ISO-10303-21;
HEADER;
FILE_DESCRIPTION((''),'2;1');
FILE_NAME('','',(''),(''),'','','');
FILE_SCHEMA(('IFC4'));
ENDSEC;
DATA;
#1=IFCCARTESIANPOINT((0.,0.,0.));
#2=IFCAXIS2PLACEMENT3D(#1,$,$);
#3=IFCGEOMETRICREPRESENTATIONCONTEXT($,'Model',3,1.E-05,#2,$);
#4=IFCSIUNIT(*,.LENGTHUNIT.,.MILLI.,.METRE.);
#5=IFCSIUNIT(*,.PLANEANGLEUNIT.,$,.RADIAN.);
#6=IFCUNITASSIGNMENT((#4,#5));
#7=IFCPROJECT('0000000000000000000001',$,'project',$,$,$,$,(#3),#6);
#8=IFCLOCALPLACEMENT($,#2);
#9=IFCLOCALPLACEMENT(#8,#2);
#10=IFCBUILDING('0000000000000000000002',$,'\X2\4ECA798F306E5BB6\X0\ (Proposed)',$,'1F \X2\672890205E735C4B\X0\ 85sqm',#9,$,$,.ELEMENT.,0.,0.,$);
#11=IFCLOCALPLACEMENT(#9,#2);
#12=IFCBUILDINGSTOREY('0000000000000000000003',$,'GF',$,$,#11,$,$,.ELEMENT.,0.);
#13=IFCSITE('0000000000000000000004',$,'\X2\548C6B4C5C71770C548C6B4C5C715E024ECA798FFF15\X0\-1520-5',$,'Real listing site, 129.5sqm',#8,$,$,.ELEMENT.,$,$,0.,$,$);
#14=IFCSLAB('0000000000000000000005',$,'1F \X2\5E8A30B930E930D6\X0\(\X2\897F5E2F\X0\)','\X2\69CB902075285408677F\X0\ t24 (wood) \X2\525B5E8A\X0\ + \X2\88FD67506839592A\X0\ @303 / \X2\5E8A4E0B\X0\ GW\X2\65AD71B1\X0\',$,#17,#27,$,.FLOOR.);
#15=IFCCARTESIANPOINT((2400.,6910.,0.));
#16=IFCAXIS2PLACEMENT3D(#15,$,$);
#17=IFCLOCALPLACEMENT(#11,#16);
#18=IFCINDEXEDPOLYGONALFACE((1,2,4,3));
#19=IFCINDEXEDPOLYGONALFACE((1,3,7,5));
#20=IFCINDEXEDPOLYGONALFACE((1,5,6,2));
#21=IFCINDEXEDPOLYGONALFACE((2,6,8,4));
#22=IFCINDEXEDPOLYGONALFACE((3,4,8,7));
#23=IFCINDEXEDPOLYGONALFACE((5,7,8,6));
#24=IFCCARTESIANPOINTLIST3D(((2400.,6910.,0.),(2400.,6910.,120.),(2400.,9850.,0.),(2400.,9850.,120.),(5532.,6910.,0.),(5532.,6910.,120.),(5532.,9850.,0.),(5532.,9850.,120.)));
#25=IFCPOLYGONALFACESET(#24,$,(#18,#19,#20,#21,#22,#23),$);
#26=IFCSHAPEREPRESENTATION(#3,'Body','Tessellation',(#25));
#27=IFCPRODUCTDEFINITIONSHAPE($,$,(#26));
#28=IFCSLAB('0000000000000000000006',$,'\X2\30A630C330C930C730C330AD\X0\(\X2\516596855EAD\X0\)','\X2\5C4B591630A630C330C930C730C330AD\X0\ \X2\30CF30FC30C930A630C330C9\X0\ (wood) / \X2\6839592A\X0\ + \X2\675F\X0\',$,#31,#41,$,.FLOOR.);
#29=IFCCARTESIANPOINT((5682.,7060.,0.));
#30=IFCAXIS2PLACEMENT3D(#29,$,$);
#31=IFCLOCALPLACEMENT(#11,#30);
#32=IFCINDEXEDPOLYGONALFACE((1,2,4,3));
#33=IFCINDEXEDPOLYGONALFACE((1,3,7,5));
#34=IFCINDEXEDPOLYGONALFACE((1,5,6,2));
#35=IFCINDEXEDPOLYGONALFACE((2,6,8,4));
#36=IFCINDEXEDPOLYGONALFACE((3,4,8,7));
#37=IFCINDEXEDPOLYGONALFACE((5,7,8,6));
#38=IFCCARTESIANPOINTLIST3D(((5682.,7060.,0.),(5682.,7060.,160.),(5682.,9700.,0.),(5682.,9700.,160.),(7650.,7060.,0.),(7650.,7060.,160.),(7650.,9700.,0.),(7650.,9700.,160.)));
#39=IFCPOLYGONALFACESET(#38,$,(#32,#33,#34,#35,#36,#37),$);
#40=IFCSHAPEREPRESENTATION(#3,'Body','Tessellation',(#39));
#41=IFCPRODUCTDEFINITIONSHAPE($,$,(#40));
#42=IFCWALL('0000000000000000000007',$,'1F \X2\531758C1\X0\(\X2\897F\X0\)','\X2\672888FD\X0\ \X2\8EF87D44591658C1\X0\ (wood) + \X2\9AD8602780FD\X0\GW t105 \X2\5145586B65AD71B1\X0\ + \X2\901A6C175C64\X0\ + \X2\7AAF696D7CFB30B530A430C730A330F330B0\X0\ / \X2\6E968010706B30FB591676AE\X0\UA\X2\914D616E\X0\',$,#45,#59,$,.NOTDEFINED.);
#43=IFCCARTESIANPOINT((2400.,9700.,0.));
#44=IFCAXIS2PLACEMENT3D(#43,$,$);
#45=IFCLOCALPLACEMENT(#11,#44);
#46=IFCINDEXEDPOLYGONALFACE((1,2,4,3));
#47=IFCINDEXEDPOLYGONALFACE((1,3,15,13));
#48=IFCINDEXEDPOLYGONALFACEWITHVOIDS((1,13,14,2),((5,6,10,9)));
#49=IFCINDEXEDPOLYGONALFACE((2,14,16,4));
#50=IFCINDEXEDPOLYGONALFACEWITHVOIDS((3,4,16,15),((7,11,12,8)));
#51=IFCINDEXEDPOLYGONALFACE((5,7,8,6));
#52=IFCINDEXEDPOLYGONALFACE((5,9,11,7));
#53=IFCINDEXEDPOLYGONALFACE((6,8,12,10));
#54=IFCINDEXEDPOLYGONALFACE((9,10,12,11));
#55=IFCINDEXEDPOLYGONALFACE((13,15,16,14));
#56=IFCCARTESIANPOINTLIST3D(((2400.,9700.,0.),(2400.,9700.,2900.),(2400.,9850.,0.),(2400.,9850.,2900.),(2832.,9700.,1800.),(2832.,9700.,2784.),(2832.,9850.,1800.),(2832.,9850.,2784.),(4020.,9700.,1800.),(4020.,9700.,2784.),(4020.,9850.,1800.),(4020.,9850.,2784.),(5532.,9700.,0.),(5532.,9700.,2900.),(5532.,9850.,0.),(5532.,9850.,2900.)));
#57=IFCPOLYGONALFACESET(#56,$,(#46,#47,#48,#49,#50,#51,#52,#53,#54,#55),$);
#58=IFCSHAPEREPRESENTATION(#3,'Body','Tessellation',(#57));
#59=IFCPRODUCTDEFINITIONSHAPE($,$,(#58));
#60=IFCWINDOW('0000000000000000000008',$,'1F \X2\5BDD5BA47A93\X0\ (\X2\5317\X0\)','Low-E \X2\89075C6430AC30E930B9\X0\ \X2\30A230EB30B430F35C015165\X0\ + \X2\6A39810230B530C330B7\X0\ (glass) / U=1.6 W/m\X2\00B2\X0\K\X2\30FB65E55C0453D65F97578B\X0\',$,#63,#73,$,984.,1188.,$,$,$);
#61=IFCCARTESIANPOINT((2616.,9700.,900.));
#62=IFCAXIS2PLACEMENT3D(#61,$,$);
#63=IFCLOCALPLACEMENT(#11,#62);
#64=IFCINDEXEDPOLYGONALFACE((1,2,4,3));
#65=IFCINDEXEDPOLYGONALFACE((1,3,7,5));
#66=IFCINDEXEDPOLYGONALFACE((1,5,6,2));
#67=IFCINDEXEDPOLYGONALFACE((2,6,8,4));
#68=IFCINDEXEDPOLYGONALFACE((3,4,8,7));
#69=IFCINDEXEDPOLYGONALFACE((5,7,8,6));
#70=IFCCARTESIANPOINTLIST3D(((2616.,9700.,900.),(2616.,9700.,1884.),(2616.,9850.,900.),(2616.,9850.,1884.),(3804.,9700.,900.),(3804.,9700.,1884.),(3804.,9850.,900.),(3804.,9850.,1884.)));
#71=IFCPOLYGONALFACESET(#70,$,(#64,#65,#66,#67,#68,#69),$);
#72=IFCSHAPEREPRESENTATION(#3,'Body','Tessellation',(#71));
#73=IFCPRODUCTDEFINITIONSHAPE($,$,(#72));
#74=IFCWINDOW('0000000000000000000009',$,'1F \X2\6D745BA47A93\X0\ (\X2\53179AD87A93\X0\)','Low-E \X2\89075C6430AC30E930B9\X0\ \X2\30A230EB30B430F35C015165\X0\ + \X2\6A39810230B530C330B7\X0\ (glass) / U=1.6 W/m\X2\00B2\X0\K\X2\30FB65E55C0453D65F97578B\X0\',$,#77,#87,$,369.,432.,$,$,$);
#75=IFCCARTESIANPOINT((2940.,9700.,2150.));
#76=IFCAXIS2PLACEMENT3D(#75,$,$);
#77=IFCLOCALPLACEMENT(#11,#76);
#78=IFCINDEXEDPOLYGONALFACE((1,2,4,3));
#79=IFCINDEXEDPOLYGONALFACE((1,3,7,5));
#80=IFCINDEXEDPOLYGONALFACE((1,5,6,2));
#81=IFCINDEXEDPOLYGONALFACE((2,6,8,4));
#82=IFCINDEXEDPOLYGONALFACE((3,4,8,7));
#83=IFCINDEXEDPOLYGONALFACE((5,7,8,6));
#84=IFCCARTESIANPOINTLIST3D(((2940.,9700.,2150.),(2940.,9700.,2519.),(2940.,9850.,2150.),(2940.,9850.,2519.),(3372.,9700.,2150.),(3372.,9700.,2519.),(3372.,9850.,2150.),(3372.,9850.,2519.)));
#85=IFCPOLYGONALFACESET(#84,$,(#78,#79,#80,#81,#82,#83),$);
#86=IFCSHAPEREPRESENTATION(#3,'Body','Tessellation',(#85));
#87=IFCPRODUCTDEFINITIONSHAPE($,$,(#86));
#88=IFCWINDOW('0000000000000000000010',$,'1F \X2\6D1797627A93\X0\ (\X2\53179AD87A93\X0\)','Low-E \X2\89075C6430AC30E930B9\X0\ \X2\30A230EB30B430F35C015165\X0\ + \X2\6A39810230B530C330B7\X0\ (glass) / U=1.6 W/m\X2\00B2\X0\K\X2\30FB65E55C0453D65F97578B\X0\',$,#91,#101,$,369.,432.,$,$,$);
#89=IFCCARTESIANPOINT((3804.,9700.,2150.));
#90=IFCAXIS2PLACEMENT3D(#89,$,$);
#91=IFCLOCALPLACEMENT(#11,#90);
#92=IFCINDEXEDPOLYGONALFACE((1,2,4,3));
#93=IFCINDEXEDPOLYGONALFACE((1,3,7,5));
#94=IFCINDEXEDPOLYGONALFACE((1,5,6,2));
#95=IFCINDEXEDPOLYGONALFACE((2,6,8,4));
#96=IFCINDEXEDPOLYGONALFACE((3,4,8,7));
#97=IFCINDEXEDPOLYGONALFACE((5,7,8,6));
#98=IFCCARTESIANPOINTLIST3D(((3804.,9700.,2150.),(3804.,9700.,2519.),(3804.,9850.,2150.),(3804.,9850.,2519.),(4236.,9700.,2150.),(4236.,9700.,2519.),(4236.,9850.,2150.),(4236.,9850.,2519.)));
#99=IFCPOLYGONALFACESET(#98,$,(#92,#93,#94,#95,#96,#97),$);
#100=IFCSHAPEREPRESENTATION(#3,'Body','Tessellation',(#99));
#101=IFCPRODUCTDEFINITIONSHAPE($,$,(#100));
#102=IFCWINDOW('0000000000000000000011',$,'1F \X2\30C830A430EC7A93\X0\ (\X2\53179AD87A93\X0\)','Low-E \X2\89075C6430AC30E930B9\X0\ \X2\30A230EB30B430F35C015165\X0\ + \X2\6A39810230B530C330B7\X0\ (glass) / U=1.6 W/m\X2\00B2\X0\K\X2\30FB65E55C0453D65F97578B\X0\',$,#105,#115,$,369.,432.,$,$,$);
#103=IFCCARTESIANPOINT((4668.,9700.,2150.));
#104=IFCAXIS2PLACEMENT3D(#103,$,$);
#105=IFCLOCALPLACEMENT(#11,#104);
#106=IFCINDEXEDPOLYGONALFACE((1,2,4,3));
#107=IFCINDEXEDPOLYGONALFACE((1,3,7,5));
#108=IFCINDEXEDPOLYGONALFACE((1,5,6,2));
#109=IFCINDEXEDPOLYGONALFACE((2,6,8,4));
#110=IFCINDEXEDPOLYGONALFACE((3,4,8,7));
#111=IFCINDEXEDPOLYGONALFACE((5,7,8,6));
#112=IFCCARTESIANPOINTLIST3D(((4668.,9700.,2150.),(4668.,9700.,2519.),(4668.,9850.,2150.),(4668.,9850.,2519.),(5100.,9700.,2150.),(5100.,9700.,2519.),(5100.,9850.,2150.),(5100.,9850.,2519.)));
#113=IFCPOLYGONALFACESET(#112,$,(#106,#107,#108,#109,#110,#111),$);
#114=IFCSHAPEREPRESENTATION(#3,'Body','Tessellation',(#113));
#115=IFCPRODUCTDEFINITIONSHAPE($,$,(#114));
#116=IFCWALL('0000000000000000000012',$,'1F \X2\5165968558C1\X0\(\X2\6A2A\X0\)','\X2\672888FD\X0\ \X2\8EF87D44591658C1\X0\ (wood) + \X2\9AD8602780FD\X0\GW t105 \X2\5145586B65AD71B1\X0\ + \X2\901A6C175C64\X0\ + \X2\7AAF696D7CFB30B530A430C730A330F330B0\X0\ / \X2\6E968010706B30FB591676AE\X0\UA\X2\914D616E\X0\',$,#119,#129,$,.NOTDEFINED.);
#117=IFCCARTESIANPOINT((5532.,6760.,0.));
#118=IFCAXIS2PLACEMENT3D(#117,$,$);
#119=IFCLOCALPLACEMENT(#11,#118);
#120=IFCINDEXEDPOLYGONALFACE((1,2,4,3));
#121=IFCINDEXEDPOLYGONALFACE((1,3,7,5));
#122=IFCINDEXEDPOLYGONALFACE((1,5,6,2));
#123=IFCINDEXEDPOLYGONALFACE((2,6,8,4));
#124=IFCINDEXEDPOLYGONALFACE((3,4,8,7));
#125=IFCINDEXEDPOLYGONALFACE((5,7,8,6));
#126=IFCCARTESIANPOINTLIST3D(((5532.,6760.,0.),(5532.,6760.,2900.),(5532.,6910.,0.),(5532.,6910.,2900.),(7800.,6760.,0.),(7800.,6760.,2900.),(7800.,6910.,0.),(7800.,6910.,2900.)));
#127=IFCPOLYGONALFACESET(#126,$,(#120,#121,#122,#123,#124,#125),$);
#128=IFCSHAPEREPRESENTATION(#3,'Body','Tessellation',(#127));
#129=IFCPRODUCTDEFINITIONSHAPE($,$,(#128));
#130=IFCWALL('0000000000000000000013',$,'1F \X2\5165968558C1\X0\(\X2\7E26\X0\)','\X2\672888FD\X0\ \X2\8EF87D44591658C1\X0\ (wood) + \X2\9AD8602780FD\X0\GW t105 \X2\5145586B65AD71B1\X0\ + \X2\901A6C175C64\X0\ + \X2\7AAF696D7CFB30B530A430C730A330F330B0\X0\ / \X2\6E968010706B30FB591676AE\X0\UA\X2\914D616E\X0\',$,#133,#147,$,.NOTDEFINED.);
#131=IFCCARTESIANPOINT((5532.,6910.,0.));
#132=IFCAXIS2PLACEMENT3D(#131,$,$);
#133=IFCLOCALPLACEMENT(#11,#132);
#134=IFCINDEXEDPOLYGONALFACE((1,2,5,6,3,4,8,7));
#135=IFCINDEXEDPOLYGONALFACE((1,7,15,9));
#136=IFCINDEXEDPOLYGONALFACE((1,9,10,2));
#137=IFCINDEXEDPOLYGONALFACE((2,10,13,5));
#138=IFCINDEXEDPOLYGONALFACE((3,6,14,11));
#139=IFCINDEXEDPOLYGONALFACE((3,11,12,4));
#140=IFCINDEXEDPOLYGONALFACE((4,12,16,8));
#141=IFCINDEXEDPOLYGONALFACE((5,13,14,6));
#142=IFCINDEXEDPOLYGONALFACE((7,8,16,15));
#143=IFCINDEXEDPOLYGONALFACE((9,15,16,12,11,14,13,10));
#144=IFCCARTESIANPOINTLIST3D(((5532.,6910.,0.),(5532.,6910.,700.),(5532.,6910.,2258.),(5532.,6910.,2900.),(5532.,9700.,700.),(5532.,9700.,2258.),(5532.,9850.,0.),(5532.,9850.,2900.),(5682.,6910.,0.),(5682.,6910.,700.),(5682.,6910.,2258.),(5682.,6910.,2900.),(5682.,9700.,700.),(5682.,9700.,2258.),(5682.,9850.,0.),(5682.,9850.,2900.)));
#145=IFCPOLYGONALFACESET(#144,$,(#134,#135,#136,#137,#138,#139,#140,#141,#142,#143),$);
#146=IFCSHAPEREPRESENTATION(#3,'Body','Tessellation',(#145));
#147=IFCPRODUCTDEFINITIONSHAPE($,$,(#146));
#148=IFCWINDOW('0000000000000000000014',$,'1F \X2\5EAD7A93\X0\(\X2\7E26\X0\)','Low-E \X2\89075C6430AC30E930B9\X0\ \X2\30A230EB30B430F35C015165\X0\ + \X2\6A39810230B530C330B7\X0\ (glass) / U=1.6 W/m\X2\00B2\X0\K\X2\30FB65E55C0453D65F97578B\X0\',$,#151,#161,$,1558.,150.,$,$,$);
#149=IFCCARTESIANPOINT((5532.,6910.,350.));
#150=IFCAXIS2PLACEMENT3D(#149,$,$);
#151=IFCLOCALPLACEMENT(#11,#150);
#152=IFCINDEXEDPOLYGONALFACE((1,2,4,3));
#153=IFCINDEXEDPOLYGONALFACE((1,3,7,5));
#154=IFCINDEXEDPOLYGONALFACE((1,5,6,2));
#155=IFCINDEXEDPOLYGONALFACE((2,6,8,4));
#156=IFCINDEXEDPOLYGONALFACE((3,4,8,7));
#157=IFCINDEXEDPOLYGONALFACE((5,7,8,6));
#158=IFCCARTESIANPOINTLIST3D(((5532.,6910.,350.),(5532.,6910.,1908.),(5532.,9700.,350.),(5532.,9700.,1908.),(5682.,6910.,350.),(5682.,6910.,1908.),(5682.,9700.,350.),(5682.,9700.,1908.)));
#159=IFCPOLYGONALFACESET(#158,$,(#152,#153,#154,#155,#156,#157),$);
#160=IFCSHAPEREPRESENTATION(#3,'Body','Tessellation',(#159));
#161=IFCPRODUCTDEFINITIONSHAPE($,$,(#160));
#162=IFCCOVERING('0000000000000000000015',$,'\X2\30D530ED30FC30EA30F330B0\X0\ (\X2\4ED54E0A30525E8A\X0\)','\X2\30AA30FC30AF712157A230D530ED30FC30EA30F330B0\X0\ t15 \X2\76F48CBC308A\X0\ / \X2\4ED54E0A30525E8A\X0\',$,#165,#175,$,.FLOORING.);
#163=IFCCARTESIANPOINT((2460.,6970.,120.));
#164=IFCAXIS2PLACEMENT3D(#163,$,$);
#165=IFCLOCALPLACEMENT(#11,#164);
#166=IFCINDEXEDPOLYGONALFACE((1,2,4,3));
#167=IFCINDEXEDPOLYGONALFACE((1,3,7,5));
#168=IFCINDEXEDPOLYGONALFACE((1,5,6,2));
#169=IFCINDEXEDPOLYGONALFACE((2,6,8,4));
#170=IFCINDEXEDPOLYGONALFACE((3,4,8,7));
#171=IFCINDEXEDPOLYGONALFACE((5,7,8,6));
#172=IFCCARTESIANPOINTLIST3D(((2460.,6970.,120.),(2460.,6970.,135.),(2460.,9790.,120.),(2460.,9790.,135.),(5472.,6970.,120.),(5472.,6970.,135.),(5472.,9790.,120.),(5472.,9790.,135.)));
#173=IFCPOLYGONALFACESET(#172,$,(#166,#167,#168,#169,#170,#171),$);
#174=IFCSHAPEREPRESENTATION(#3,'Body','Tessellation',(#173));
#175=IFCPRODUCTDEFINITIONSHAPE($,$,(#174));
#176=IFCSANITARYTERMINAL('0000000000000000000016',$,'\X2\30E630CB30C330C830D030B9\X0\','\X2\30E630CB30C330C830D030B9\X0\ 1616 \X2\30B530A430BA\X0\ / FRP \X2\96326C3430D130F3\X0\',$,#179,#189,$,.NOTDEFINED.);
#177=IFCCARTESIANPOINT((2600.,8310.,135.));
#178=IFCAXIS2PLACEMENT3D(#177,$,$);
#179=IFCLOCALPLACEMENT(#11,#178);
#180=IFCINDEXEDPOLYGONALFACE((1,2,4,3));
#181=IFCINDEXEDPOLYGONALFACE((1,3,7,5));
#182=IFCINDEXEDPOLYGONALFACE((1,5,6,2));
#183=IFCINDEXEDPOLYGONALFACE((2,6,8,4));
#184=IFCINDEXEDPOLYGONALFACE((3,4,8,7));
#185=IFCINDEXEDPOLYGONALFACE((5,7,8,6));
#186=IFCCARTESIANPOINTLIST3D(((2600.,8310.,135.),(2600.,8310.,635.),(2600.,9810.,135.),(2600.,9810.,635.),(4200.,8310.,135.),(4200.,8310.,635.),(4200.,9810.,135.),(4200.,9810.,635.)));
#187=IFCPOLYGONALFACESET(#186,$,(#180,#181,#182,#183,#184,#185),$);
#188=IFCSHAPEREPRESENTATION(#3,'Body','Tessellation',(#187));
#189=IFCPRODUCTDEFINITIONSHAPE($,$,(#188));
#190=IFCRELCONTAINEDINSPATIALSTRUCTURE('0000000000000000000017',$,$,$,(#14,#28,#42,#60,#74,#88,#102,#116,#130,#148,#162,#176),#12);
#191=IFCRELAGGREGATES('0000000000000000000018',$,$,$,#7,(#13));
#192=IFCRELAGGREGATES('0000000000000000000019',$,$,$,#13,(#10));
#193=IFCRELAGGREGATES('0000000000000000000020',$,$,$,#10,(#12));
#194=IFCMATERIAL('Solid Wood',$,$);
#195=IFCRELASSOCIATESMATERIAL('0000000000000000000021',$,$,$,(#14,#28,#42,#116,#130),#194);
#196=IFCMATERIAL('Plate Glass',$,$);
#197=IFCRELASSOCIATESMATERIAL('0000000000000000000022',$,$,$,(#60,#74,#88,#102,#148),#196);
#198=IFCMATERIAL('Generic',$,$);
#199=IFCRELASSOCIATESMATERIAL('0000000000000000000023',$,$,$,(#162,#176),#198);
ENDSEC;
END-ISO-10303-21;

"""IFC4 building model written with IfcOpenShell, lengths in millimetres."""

from ifc_helpers import new_model, si_unit, frame, frame_2d, origin, place, context, project, spatial, rectangle, extrude, material, element, fill, save


model = new_model("IFC4")

# Units and contexts
model_context = context("Model", 3, precision=1e-05, world=origin())
ifc_project = project(units=[si_unit("LENGTHUNIT", "METRE", prefix="MILLI"), si_unit("PLANEANGLEUNIT", "RADIAN")], contexts=[model_context])

# Site, building, storey
site_placement = place(None, origin())
site = spatial("IfcSite", under=ifc_project, at=site_placement, Name="和歌山県和歌山市今福５-1520-5", ObjectType="Real listing site, 129.5sqm", CompositionType="ELEMENT", RefElevation=0.0)
building_placement = place(site_placement, origin())
building = spatial("IfcBuilding", under=site, at=building_placement, Name="今福の家 (Proposed)", ObjectType="1F 木造平屋 85sqm", CompositionType="ELEMENT", ElevationOfRefHeight=0.0, ElevationOfTerrain=0.0)
storey_placement = place(building_placement, origin())
storey = spatial("IfcBuildingStorey", under=building, at=storey_placement, Name="GF", CompositionType="ELEMENT", Elevation=0.0)

# Slabs
ifc_material_1 = material(Name="Solid Wood")
slab_1_placement = place(storey_placement, frame((2400.0, 6910.0, 0.0)))
element("IfcSlab", 1, at=slab_1_placement, inside=storey, material=ifc_material_1, Name="1F 床スラブ(西帯)", Description="構造用合板 t24 (wood) 剛床 + 製材根太 @303 / 床下 GW断熱", PredefinedType="FLOOR", context=model_context, shape_type="SweptSolid", body=[
    extrude(rectangle(XDim=3132.0, YDim=2940.0, at=frame_2d((1566.0, 1470.0))), frame((2400.0, 6910.0, 0.0)), (0.0, 0.0, 1.0), 120.0),
])
slab_2_placement = place(storey_placement, frame((5682.0, 7060.0, 0.0)))
element("IfcSlab", 2, at=slab_2_placement, inside=storey, material=ifc_material_1, Name="ウッドデッキ(入隅庭)", Description="屋外ウッドデッキ ハードウッド (wood) / 根太 + 束", PredefinedType="FLOOR", context=model_context, shape_type="SweptSolid", body=[
    extrude(rectangle(XDim=1968.0, YDim=2640.0, at=frame_2d((984.0, 1320.0))), frame((5682.0, 7060.0, 0.0)), (0.0, 0.0, 1.0), 160.0),
])

# Wall, openings, windows
wall_1_placement = place(storey_placement, frame((2400.0, 9700.0, 0.0)))
wall_1 = element("IfcWall", 3, at=wall_1_placement, inside=storey, material=ifc_material_1, Name="1F 北壁(西)", Description="木製 軸組外壁 (wood) + 高性能GW t105 充填断熱 + 通気層 + 窯業系サイディング / 準耐火・外皮UA配慮", PredefinedType="NOTDEFINED", context=model_context, shape_type="SweptSolid", body=[
    extrude(rectangle(XDim=3132.0, YDim=150.0, at=frame_2d((1566.0, 75.0))), frame((2400.0, 9700.0, 0.0)), (0.0, 0.0, 1.0), 2900.0),
])
opening_1_placement = place(storey_placement, frame((2616.0, 9700.0, 900.0)))
opening_1 = element("IfcOpeningElement", 4, at=opening_1_placement, cuts=wall_1, PredefinedType="NOTDEFINED", context=model_context, shape_type="SweptSolid", body=[
    extrude(rectangle(XDim=1188.0, YDim=150.0, at=frame_2d((594.0, 75.0))), frame((2616.0, 9700.0, 900.0)), (0.0, 0.0, 1.0), 984.0),
])
opening_2_placement = place(storey_placement, frame((2940.0, 9700.0, 2150.0)))
opening_2 = element("IfcOpeningElement", 5, at=opening_2_placement, cuts=wall_1, PredefinedType="NOTDEFINED", context=model_context, shape_type="SweptSolid", body=[
    extrude(rectangle(XDim=432.0, YDim=150.0, at=frame_2d((216.0, 75.0))), frame((2940.0, 9700.0, 2150.0)), (0.0, 0.0, 1.0), 369.0),
])
opening_3_placement = place(storey_placement, frame((3804.0, 9700.0, 2150.0)))
opening_3 = element("IfcOpeningElement", 6, at=opening_3_placement, cuts=wall_1, PredefinedType="NOTDEFINED", context=model_context, shape_type="SweptSolid", body=[
    extrude(rectangle(XDim=432.0, YDim=150.0, at=frame_2d((216.0, 75.0))), frame((3804.0, 9700.0, 2150.0)), (0.0, 0.0, 1.0), 369.0),
])
opening_4_placement = place(storey_placement, frame((4668.0, 9700.0, 2150.0)))
opening_4 = element("IfcOpeningElement", 7, at=opening_4_placement, cuts=wall_1, PredefinedType="NOTDEFINED", context=model_context, shape_type="SweptSolid", body=[
    extrude(rectangle(XDim=432.0, YDim=150.0, at=frame_2d((216.0, 75.0))), frame((4668.0, 9700.0, 2150.0)), (0.0, 0.0, 1.0), 369.0),
])
ifc_material_2 = material(Name="Plate Glass")
window_1_placement = place(storey_placement, frame((2616.0, 9700.0, 900.0)))
window_1 = element("IfcWindow", 8, at=window_1_placement, inside=storey, material=ifc_material_2, Name="1F 寝室窓 (北)", Description="Low-E 複層ガラス アルゴン封入 + 樹脂サッシ (glass) / U=1.6 W/m²K・日射取得型", OverallHeight=984.0, OverallWidth=1188.0, context=model_context, shape_type="SweptSolid", body=[
    extrude(rectangle(XDim=1188.0, YDim=150.0, at=frame_2d((594.0, 75.0))), frame((2616.0, 9700.0, 900.0)), (0.0, 0.0, 1.0), 984.0),
])
fill(opening_1, window_1)
window_2_placement = place(storey_placement, frame((2940.0, 9700.0, 2150.0)))
window_2 = element("IfcWindow", 9, at=window_2_placement, inside=storey, material=ifc_material_2, Name="1F 浴室窓 (北高窓)", Description="Low-E 複層ガラス アルゴン封入 + 樹脂サッシ (glass) / U=1.6 W/m²K・日射取得型", OverallHeight=369.0, OverallWidth=432.0, context=model_context, shape_type="SweptSolid", body=[
    extrude(rectangle(XDim=432.0, YDim=150.0, at=frame_2d((216.0, 75.0))), frame((2940.0, 9700.0, 2150.0)), (0.0, 0.0, 1.0), 369.0),
])
fill(opening_2, window_2)
window_3_placement = place(storey_placement, frame((3804.0, 9700.0, 2150.0)))
window_3 = element("IfcWindow", 10, at=window_3_placement, inside=storey, material=ifc_material_2, Name="1F 洗面窓 (北高窓)", Description="Low-E 複層ガラス アルゴン封入 + 樹脂サッシ (glass) / U=1.6 W/m²K・日射取得型", OverallHeight=369.0, OverallWidth=432.0, context=model_context, shape_type="SweptSolid", body=[
    extrude(rectangle(XDim=432.0, YDim=150.0, at=frame_2d((216.0, 75.0))), frame((3804.0, 9700.0, 2150.0)), (0.0, 0.0, 1.0), 369.0),
])
fill(opening_3, window_3)
window_4_placement = place(storey_placement, frame((4668.0, 9700.0, 2150.0)))
window_4 = element("IfcWindow", 11, at=window_4_placement, inside=storey, material=ifc_material_2, Name="1F トイレ窓 (北高窓)", Description="Low-E 複層ガラス アルゴン封入 + 樹脂サッシ (glass) / U=1.6 W/m²K・日射取得型", OverallHeight=369.0, OverallWidth=432.0, context=model_context, shape_type="SweptSolid", body=[
    extrude(rectangle(XDim=432.0, YDim=150.0, at=frame_2d((216.0, 75.0))), frame((4668.0, 9700.0, 2150.0)), (0.0, 0.0, 1.0), 369.0),
])
fill(opening_4, window_4)

# Wall
wall_2_placement = place(storey_placement, frame((5532.0, 6760.0, 0.0)))
element("IfcWall", 12, at=wall_2_placement, inside=storey, material=ifc_material_1, Name="1F 入隅壁(横)", Description="木製 軸組外壁 (wood) + 高性能GW t105 充填断熱 + 通気層 + 窯業系サイディング / 準耐火・外皮UA配慮", PredefinedType="NOTDEFINED", context=model_context, shape_type="SweptSolid", body=[
    extrude(rectangle(XDim=2268.0, YDim=150.0, at=frame_2d((1134.0, 75.0))), frame((5532.0, 6760.0, 0.0)), (0.0, 0.0, 1.0), 2900.0),
])

# Wall, opening, window
wall_3_placement = place(storey_placement, frame((5532.0, 6910.0, 0.0)))
wall_3 = element("IfcWall", 13, at=wall_3_placement, inside=storey, material=ifc_material_1, Name="1F 入隅壁(縦)", Description="木製 軸組外壁 (wood) + 高性能GW t105 充填断熱 + 通気層 + 窯業系サイディング / 準耐火・外皮UA配慮", PredefinedType="NOTDEFINED", context=model_context, shape_type="SweptSolid", body=[
    extrude(rectangle(XDim=150.0, YDim=2940.0, at=frame_2d((75.0, 1470.0))), frame((5532.0, 6910.0, 0.0)), (0.0, 0.0, 1.0), 2900.0),
])
opening_5_placement = place(storey_placement, frame((5532.0, 6910.0, 350.0)))
opening_5 = element("IfcOpeningElement", 14, at=opening_5_placement, cuts=wall_3, PredefinedType="NOTDEFINED", context=model_context, shape_type="SweptSolid", body=[
    extrude(rectangle(XDim=150.0, YDim=2790.0, at=frame_2d((75.0, 1395.0))), frame((5532.0, 6910.0, 350.0)), (0.0, 0.0, 1.0), 1558.0),
])
window_5_placement = place(storey_placement, frame((5532.0, 6910.0, 350.0)))
window_5 = element("IfcWindow", 15, at=window_5_placement, inside=storey, material=ifc_material_2, Name="1F 庭窓(縦)", Description="Low-E 複層ガラス アルゴン封入 + 樹脂サッシ (glass) / U=1.6 W/m²K・日射取得型", OverallHeight=1558.0, OverallWidth=150.0, context=model_context, shape_type="SweptSolid", body=[
    extrude(rectangle(XDim=150.0, YDim=2790.0, at=frame_2d((75.0, 1395.0))), frame((5532.0, 6910.0, 350.0)), (0.0, 0.0, 1.0), 1558.0),
])
fill(opening_5, window_5)

# Covering
ifc_material_3 = material(Name="Generic")
covering_placement = place(storey_placement, frame((2460.0, 6970.0, 120.0)))
element("IfcCovering", 16, at=covering_placement, inside=storey, material=ifc_material_3, Name="フローリング (仕上げ床)", Description="オーク無垢フローリング t15 直貼り / 仕上げ床", PredefinedType="FLOORING", context=model_context, shape_type="SweptSolid", body=[
    extrude(rectangle(XDim=3012.0, YDim=2820.0, at=frame_2d((1506.0, 1410.0))), frame((2460.0, 6970.0, 120.0)), (0.0, 0.0, 1.0), 15.0),
])

# Sanitary terminal
sanitary_terminal_1_placement = place(storey_placement, frame((2600.0, 8310.0, 135.0)))
element("IfcSanitaryTerminal", 17, at=sanitary_terminal_1_placement, inside=storey, material=ifc_material_3, Name="ユニットバス", Description="ユニットバス 1616 サイズ / FRP 防水パン", PredefinedType="NOTDEFINED", context=model_context, shape_type="SweptSolid", body=[
    extrude(rectangle(XDim=1600.0, YDim=1500.0, at=frame_2d((800.0, 750.0))), frame((2600.0, 8310.0, 135.0)), (0.0, 0.0, 1.0), 500.0),
])

save(model, "model.ifc")
